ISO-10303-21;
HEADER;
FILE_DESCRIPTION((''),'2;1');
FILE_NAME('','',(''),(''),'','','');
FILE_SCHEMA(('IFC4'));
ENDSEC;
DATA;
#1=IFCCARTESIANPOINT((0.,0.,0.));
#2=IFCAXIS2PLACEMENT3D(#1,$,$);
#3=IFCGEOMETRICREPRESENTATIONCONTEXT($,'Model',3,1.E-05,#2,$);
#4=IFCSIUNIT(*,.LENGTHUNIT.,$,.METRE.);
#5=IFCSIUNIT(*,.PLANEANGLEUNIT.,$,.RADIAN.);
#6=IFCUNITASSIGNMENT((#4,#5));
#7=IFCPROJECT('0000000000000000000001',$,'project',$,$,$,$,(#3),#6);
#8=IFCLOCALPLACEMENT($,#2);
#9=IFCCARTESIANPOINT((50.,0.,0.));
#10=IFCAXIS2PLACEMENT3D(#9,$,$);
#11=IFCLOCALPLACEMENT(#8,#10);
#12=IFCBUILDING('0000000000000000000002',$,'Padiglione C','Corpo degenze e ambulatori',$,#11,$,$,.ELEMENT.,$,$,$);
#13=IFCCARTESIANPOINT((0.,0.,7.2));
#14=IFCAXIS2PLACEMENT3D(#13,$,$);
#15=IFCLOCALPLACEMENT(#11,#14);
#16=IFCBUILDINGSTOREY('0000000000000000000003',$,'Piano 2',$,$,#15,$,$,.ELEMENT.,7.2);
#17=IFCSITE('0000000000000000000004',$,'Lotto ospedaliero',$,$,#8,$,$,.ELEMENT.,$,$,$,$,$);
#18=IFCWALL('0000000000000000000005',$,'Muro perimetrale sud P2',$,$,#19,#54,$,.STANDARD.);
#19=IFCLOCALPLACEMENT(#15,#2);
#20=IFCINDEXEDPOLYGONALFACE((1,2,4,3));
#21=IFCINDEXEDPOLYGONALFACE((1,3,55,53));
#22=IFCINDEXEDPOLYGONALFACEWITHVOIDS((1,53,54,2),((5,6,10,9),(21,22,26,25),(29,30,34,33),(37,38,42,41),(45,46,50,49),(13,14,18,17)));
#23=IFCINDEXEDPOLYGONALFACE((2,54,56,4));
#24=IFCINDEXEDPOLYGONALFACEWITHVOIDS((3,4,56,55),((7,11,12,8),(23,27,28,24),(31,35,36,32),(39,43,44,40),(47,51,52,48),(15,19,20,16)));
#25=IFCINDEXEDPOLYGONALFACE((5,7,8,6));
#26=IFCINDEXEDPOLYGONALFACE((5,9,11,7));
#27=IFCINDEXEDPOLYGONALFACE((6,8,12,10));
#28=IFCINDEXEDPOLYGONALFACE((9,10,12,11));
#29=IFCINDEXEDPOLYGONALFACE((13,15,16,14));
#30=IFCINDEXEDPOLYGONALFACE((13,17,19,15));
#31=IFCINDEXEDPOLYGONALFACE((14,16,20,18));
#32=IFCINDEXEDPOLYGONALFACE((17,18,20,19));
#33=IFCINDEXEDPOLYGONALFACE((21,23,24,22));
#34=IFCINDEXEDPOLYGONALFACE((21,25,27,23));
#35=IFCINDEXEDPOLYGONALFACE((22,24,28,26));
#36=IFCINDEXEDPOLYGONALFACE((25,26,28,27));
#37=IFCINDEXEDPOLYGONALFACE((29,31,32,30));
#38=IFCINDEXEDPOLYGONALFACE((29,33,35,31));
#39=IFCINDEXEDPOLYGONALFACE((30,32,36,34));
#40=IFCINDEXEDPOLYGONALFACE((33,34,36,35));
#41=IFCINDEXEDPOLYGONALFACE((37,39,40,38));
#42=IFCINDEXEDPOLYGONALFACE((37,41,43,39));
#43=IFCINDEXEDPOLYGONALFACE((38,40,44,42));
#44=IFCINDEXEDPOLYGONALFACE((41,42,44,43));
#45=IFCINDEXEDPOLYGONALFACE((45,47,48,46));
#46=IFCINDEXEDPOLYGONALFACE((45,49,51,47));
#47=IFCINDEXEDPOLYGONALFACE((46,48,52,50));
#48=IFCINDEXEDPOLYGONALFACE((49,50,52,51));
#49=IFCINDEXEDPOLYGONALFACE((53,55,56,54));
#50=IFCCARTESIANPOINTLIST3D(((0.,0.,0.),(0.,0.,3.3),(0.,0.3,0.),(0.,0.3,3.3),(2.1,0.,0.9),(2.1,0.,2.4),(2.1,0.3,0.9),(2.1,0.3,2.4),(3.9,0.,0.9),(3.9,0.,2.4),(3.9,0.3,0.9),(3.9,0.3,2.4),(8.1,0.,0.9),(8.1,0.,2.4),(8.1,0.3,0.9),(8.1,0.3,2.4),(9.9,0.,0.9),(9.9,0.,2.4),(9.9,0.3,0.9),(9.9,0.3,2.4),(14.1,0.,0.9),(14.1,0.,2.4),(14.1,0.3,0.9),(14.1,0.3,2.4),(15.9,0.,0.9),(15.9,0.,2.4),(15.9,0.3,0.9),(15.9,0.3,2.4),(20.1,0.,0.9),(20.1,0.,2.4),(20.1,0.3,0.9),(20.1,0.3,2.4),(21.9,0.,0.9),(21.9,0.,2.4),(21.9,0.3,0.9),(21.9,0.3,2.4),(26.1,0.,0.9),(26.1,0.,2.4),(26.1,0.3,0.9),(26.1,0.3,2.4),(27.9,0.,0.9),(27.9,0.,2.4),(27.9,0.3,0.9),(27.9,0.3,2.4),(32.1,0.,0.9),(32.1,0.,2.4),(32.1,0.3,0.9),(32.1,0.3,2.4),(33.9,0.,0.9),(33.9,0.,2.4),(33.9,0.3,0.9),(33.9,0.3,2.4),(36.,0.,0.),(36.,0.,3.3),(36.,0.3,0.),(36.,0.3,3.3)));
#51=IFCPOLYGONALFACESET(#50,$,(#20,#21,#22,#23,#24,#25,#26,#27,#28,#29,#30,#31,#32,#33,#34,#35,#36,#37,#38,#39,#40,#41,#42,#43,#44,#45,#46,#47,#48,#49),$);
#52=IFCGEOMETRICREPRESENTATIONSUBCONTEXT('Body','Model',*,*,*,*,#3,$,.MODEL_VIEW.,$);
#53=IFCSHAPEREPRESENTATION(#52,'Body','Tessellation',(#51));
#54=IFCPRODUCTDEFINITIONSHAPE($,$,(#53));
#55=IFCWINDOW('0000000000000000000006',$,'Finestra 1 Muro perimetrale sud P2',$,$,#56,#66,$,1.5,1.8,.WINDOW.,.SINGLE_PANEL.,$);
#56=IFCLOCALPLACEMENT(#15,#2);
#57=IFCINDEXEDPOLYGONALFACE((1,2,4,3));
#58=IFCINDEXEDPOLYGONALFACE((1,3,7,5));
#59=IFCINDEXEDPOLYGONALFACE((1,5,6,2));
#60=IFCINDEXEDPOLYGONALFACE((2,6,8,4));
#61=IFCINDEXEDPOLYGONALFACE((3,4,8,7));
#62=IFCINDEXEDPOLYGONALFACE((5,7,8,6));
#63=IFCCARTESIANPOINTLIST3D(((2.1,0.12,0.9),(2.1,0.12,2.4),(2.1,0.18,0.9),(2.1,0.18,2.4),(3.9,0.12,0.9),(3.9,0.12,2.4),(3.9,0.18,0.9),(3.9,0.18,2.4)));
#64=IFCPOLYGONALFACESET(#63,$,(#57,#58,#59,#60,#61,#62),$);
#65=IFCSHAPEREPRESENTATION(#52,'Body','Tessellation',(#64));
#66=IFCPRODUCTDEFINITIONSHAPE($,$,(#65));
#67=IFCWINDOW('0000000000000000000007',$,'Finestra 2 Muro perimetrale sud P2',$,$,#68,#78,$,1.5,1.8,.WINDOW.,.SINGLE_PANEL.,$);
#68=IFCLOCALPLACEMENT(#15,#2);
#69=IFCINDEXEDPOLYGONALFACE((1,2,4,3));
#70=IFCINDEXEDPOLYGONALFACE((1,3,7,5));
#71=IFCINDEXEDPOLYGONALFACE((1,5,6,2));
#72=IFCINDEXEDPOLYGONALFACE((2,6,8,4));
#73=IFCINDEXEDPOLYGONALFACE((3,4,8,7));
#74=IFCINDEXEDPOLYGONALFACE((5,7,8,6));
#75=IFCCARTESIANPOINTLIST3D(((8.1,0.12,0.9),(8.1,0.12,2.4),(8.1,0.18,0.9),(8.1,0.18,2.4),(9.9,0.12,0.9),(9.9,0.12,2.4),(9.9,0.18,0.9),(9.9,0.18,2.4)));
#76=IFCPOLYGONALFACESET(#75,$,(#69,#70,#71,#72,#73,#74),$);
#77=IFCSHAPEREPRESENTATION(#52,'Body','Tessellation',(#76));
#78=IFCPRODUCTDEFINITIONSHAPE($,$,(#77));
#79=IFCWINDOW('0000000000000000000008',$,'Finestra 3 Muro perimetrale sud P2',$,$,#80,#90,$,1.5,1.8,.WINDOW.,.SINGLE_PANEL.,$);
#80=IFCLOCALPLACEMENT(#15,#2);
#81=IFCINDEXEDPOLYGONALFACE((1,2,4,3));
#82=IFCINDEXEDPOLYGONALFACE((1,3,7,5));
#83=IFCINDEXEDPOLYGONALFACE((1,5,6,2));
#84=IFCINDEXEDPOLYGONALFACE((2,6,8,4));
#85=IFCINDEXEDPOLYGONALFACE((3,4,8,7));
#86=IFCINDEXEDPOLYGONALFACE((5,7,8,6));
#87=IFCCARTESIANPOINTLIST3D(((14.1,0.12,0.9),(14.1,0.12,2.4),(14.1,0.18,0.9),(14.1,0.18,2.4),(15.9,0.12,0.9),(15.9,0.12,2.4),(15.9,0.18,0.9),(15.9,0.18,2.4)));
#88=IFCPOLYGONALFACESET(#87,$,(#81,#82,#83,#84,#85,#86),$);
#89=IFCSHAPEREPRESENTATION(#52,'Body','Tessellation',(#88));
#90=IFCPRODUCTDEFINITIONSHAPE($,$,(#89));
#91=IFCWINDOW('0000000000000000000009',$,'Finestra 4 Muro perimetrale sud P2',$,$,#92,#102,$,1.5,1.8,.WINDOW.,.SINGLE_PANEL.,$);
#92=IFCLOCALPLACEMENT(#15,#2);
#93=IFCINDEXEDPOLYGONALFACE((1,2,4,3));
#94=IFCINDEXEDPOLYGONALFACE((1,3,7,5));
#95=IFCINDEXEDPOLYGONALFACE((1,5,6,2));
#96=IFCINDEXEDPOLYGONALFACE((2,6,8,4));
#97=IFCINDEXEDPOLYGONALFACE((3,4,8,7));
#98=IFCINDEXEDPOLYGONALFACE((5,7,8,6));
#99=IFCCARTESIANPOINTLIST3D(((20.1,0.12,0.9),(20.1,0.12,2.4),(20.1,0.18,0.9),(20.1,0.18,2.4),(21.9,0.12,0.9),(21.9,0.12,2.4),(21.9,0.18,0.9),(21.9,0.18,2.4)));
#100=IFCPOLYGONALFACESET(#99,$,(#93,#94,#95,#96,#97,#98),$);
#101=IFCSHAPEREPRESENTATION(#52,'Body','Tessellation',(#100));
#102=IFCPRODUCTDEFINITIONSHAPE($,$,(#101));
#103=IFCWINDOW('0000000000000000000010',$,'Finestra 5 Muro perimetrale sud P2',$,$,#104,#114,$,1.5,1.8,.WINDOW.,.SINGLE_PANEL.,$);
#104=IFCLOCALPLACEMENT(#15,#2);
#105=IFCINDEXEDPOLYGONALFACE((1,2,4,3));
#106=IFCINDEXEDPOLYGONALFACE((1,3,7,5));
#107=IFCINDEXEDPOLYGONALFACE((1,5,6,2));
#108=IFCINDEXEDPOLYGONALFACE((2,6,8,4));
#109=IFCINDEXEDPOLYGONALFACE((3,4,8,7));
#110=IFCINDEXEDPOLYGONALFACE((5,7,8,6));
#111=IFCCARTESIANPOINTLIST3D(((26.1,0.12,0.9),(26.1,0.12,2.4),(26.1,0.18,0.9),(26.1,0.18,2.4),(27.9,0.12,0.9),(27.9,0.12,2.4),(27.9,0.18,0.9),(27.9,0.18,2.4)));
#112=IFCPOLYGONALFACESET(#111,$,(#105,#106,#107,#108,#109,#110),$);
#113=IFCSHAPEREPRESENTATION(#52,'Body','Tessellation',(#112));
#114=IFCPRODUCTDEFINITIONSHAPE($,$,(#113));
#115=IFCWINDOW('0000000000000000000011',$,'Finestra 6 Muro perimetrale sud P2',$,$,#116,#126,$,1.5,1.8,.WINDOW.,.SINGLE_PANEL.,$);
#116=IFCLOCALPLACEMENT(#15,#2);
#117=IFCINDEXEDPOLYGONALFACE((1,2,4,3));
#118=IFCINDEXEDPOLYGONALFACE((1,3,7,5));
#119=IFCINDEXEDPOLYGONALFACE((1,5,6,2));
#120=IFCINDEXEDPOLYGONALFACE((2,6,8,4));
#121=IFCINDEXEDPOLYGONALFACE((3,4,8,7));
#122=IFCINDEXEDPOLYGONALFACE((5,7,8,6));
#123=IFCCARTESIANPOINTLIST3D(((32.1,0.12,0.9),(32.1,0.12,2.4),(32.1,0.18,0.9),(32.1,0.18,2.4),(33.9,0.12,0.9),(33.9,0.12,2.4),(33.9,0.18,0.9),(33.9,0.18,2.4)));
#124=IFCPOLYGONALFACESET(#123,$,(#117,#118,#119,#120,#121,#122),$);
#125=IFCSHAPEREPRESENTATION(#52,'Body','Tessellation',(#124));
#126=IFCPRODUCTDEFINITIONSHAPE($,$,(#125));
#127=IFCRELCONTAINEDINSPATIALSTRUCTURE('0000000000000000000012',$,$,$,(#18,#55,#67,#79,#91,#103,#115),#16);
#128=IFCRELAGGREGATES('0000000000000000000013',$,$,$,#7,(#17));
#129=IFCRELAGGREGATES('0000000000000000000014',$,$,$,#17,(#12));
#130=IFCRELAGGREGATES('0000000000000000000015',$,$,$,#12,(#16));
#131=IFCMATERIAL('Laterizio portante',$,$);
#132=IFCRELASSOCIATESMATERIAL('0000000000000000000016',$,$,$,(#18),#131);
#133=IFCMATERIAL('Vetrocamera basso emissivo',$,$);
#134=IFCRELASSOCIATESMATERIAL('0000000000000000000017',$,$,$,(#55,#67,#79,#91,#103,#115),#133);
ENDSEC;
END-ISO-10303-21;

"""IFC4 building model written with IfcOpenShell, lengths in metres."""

from ifc_helpers import new_model, si_unit, frame, frame_2d, origin, place, context, subcontext, project, spatial, rectangle, extrude, material, element, fill, save


model = new_model("IFC4")

# Units and contexts
model_context = context("Model", 3, precision=1e-05, world=origin())
body_context = subcontext(model_context, "Body", "Model", "MODEL_VIEW")
ifc_project = project(units=[si_unit("LENGTHUNIT", "METRE"), si_unit("PLANEANGLEUNIT", "RADIAN")], contexts=[model_context])

# Site, building, storey
site_placement = place(None, origin())
site = spatial("IfcSite", under=ifc_project, at=site_placement, Name="Lotto ospedaliero", CompositionType="ELEMENT")
building_placement = place(site_placement, frame((50.0, 0.0, 0.0)))
building = spatial("IfcBuilding", under=site, at=building_placement, Name="Padiglione C", Description="Corpo degenze e ambulatori", CompositionType="ELEMENT")
storey_placement = place(building_placement, frame((0.0, 0.0, 7.2)))
storey = spatial("IfcBuildingStorey", under=building, at=storey_placement, Name="Piano 2", CompositionType="ELEMENT", Elevation=7.2)

# Wall, openings, windows
ifc_material_1 = material(Name="Laterizio portante")
wall_1_placement = place(storey_placement, origin())
wall_1 = element("IfcWall", 1, at=wall_1_placement, inside=storey, material=ifc_material_1, Name="Muro perimetrale sud P2", PredefinedType="STANDARD", context=body_context, shape_type="SweptSolid", body=[
    extrude(rectangle(XDim=36.0, YDim=0.3, at=frame_2d((18.0, 0.15))), origin(), (0.0, 0.0, 1.0), 3.3),
])
opening_1_placement = place(wall_1_placement, frame((2.1, -0.1, 0.9)))
opening_1 = element("IfcOpeningElement", 2, at=opening_1_placement, cuts=wall_1, PredefinedType="OPENING", context=body_context, shape_type="SweptSolid", body=[
    extrude(rectangle(XDim=1.8, YDim=0.5, at=frame_2d((0.9, 0.25))), origin(), (0.0, 0.0, 1.0), 1.5),
])
opening_2_placement = place(wall_1_placement, frame((8.1, -0.1, 0.9)))
opening_2 = element("IfcOpeningElement", 3, at=opening_2_placement, cuts=wall_1, PredefinedType="OPENING", context=body_context, shape_type="SweptSolid", body=[
    extrude(rectangle(XDim=1.8, YDim=0.5, at=frame_2d((0.9, 0.25))), origin(), (0.0, 0.0, 1.0), 1.5),
])
opening_3_placement = place(wall_1_placement, frame((14.1, -0.1, 0.9)))
opening_3 = element("IfcOpeningElement", 4, at=opening_3_placement, cuts=wall_1, PredefinedType="OPENING", context=body_context, shape_type="SweptSolid", body=[
    extrude(rectangle(XDim=1.8, YDim=0.5, at=frame_2d((0.9, 0.25))), origin(), (0.0, 0.0, 1.0), 1.5),
])
opening_4_placement = place(wall_1_placement, frame((20.1, -0.1, 0.9)))
opening_4 = element("IfcOpeningElement", 5, at=opening_4_placement, cuts=wall_1, PredefinedType="OPENING", context=body_context, shape_type="SweptSolid", body=[
    extrude(rectangle(XDim=1.8, YDim=0.5, at=frame_2d((0.9, 0.25))), origin(), (0.0, 0.0, 1.0), 1.5),
])
opening_5_placement = place(wall_1_placement, frame((26.1, -0.1, 0.9)))
opening_5 = element("IfcOpeningElement", 6, at=opening_5_placement, cuts=wall_1, PredefinedType="OPENING", context=body_context, shape_type="SweptSolid", body=[
    extrude(rectangle(XDim=1.8, YDim=0.5, at=frame_2d((0.9, 0.25))), origin(), (0.0, 0.0, 1.0), 1.5),
])
opening_6_placement = place(wall_1_placement, frame((32.1, -0.1, 0.9)))
opening_6 = element("IfcOpeningElement", 7, at=opening_6_placement, cuts=wall_1, PredefinedType="OPENING", context=body_context, shape_type="SweptSolid", body=[
    extrude(rectangle(XDim=1.8, YDim=0.5, at=frame_2d((0.9, 0.25))), origin(), (0.0, 0.0, 1.0), 1.5),
])
ifc_material_2 = material(Name="Vetrocamera basso emissivo")
window_1_placement = place(wall_1_placement, frame((2.1, 0.12, 0.9)))
window_1 = element("IfcWindow", 8, at=window_1_placement, inside=storey, material=ifc_material_2, Name="Finestra 1 Muro perimetrale sud P2", OverallHeight=1.5, OverallWidth=1.8, PartitioningType="SINGLE_PANEL", PredefinedType="WINDOW", context=body_context, shape_type="SweptSolid", body=[
    extrude(rectangle(XDim=1.8, YDim=0.06, at=frame_2d((0.9, 0.03))), origin(), (0.0, 0.0, 1.0), 1.5),
])
fill(opening_1, window_1)
window_2_placement = place(wall_1_placement, frame((8.1, 0.12, 0.9)))
window_2 = element("IfcWindow", 9, at=window_2_placement, inside=storey, material=ifc_material_2, Name="Finestra 2 Muro perimetrale sud P2", OverallHeight=1.5, OverallWidth=1.8, PartitioningType="SINGLE_PANEL", PredefinedType="WINDOW", context=body_context, shape_type="SweptSolid", body=[
    extrude(rectangle(XDim=1.8, YDim=0.06, at=frame_2d((0.9, 0.03))), origin(), (0.0, 0.0, 1.0), 1.5),
])
fill(opening_2, window_2)
window_3_placement = place(wall_1_placement, frame((14.1, 0.12, 0.9)))
window_3 = element("IfcWindow", 10, at=window_3_placement, inside=storey, material=ifc_material_2, Name="Finestra 3 Muro perimetrale sud P2", OverallHeight=1.5, OverallWidth=1.8, PartitioningType="SINGLE_PANEL", PredefinedType="WINDOW", context=body_context, shape_type="SweptSolid", body=[
    extrude(rectangle(XDim=1.8, YDim=0.06, at=frame_2d((0.9, 0.03))), origin(), (0.0, 0.0, 1.0), 1.5),
])
fill(opening_3, window_3)
window_4_placement = place(wall_1_placement, frame((20.1, 0.12, 0.9)))
window_4 = element("IfcWindow", 11, at=window_4_placement, inside=storey, material=ifc_material_2, Name="Finestra 4 Muro perimetrale sud P2", OverallHeight=1.5, OverallWidth=1.8, PartitioningType="SINGLE_PANEL", PredefinedType="WINDOW", context=body_context, shape_type="SweptSolid", body=[
    extrude(rectangle(XDim=1.8, YDim=0.06, at=frame_2d((0.9, 0.03))), origin(), (0.0, 0.0, 1.0), 1.5),
])
fill(opening_4, window_4)
window_5_placement = place(wall_1_placement, frame((26.1, 0.12, 0.9)))
window_5 = element("IfcWindow", 12, at=window_5_placement, inside=storey, material=ifc_material_2, Name="Finestra 5 Muro perimetrale sud P2", OverallHeight=1.5, OverallWidth=1.8, PartitioningType="SINGLE_PANEL", PredefinedType="WINDOW", context=body_context, shape_type="SweptSolid", body=[
    extrude(rectangle(XDim=1.8, YDim=0.06, at=frame_2d((0.9, 0.03))), origin(), (0.0, 0.0, 1.0), 1.5),
])
fill(opening_5, window_5)
window_6_placement = place(wall_1_placement, frame((32.1, 0.12, 0.9)))
window_6 = element("IfcWindow", 13, at=window_6_placement, inside=storey, material=ifc_material_2, Name="Finestra 6 Muro perimetrale sud P2", OverallHeight=1.5, OverallWidth=1.8, PartitioningType="SINGLE_PANEL", PredefinedType="WINDOW", context=body_context, shape_type="SweptSolid", body=[
    extrude(rectangle(XDim=1.8, YDim=0.06, at=frame_2d((0.9, 0.03))), origin(), (0.0, 0.0, 1.0), 1.5),
])
fill(opening_6, window_6)

save(model, "model.ifc")
